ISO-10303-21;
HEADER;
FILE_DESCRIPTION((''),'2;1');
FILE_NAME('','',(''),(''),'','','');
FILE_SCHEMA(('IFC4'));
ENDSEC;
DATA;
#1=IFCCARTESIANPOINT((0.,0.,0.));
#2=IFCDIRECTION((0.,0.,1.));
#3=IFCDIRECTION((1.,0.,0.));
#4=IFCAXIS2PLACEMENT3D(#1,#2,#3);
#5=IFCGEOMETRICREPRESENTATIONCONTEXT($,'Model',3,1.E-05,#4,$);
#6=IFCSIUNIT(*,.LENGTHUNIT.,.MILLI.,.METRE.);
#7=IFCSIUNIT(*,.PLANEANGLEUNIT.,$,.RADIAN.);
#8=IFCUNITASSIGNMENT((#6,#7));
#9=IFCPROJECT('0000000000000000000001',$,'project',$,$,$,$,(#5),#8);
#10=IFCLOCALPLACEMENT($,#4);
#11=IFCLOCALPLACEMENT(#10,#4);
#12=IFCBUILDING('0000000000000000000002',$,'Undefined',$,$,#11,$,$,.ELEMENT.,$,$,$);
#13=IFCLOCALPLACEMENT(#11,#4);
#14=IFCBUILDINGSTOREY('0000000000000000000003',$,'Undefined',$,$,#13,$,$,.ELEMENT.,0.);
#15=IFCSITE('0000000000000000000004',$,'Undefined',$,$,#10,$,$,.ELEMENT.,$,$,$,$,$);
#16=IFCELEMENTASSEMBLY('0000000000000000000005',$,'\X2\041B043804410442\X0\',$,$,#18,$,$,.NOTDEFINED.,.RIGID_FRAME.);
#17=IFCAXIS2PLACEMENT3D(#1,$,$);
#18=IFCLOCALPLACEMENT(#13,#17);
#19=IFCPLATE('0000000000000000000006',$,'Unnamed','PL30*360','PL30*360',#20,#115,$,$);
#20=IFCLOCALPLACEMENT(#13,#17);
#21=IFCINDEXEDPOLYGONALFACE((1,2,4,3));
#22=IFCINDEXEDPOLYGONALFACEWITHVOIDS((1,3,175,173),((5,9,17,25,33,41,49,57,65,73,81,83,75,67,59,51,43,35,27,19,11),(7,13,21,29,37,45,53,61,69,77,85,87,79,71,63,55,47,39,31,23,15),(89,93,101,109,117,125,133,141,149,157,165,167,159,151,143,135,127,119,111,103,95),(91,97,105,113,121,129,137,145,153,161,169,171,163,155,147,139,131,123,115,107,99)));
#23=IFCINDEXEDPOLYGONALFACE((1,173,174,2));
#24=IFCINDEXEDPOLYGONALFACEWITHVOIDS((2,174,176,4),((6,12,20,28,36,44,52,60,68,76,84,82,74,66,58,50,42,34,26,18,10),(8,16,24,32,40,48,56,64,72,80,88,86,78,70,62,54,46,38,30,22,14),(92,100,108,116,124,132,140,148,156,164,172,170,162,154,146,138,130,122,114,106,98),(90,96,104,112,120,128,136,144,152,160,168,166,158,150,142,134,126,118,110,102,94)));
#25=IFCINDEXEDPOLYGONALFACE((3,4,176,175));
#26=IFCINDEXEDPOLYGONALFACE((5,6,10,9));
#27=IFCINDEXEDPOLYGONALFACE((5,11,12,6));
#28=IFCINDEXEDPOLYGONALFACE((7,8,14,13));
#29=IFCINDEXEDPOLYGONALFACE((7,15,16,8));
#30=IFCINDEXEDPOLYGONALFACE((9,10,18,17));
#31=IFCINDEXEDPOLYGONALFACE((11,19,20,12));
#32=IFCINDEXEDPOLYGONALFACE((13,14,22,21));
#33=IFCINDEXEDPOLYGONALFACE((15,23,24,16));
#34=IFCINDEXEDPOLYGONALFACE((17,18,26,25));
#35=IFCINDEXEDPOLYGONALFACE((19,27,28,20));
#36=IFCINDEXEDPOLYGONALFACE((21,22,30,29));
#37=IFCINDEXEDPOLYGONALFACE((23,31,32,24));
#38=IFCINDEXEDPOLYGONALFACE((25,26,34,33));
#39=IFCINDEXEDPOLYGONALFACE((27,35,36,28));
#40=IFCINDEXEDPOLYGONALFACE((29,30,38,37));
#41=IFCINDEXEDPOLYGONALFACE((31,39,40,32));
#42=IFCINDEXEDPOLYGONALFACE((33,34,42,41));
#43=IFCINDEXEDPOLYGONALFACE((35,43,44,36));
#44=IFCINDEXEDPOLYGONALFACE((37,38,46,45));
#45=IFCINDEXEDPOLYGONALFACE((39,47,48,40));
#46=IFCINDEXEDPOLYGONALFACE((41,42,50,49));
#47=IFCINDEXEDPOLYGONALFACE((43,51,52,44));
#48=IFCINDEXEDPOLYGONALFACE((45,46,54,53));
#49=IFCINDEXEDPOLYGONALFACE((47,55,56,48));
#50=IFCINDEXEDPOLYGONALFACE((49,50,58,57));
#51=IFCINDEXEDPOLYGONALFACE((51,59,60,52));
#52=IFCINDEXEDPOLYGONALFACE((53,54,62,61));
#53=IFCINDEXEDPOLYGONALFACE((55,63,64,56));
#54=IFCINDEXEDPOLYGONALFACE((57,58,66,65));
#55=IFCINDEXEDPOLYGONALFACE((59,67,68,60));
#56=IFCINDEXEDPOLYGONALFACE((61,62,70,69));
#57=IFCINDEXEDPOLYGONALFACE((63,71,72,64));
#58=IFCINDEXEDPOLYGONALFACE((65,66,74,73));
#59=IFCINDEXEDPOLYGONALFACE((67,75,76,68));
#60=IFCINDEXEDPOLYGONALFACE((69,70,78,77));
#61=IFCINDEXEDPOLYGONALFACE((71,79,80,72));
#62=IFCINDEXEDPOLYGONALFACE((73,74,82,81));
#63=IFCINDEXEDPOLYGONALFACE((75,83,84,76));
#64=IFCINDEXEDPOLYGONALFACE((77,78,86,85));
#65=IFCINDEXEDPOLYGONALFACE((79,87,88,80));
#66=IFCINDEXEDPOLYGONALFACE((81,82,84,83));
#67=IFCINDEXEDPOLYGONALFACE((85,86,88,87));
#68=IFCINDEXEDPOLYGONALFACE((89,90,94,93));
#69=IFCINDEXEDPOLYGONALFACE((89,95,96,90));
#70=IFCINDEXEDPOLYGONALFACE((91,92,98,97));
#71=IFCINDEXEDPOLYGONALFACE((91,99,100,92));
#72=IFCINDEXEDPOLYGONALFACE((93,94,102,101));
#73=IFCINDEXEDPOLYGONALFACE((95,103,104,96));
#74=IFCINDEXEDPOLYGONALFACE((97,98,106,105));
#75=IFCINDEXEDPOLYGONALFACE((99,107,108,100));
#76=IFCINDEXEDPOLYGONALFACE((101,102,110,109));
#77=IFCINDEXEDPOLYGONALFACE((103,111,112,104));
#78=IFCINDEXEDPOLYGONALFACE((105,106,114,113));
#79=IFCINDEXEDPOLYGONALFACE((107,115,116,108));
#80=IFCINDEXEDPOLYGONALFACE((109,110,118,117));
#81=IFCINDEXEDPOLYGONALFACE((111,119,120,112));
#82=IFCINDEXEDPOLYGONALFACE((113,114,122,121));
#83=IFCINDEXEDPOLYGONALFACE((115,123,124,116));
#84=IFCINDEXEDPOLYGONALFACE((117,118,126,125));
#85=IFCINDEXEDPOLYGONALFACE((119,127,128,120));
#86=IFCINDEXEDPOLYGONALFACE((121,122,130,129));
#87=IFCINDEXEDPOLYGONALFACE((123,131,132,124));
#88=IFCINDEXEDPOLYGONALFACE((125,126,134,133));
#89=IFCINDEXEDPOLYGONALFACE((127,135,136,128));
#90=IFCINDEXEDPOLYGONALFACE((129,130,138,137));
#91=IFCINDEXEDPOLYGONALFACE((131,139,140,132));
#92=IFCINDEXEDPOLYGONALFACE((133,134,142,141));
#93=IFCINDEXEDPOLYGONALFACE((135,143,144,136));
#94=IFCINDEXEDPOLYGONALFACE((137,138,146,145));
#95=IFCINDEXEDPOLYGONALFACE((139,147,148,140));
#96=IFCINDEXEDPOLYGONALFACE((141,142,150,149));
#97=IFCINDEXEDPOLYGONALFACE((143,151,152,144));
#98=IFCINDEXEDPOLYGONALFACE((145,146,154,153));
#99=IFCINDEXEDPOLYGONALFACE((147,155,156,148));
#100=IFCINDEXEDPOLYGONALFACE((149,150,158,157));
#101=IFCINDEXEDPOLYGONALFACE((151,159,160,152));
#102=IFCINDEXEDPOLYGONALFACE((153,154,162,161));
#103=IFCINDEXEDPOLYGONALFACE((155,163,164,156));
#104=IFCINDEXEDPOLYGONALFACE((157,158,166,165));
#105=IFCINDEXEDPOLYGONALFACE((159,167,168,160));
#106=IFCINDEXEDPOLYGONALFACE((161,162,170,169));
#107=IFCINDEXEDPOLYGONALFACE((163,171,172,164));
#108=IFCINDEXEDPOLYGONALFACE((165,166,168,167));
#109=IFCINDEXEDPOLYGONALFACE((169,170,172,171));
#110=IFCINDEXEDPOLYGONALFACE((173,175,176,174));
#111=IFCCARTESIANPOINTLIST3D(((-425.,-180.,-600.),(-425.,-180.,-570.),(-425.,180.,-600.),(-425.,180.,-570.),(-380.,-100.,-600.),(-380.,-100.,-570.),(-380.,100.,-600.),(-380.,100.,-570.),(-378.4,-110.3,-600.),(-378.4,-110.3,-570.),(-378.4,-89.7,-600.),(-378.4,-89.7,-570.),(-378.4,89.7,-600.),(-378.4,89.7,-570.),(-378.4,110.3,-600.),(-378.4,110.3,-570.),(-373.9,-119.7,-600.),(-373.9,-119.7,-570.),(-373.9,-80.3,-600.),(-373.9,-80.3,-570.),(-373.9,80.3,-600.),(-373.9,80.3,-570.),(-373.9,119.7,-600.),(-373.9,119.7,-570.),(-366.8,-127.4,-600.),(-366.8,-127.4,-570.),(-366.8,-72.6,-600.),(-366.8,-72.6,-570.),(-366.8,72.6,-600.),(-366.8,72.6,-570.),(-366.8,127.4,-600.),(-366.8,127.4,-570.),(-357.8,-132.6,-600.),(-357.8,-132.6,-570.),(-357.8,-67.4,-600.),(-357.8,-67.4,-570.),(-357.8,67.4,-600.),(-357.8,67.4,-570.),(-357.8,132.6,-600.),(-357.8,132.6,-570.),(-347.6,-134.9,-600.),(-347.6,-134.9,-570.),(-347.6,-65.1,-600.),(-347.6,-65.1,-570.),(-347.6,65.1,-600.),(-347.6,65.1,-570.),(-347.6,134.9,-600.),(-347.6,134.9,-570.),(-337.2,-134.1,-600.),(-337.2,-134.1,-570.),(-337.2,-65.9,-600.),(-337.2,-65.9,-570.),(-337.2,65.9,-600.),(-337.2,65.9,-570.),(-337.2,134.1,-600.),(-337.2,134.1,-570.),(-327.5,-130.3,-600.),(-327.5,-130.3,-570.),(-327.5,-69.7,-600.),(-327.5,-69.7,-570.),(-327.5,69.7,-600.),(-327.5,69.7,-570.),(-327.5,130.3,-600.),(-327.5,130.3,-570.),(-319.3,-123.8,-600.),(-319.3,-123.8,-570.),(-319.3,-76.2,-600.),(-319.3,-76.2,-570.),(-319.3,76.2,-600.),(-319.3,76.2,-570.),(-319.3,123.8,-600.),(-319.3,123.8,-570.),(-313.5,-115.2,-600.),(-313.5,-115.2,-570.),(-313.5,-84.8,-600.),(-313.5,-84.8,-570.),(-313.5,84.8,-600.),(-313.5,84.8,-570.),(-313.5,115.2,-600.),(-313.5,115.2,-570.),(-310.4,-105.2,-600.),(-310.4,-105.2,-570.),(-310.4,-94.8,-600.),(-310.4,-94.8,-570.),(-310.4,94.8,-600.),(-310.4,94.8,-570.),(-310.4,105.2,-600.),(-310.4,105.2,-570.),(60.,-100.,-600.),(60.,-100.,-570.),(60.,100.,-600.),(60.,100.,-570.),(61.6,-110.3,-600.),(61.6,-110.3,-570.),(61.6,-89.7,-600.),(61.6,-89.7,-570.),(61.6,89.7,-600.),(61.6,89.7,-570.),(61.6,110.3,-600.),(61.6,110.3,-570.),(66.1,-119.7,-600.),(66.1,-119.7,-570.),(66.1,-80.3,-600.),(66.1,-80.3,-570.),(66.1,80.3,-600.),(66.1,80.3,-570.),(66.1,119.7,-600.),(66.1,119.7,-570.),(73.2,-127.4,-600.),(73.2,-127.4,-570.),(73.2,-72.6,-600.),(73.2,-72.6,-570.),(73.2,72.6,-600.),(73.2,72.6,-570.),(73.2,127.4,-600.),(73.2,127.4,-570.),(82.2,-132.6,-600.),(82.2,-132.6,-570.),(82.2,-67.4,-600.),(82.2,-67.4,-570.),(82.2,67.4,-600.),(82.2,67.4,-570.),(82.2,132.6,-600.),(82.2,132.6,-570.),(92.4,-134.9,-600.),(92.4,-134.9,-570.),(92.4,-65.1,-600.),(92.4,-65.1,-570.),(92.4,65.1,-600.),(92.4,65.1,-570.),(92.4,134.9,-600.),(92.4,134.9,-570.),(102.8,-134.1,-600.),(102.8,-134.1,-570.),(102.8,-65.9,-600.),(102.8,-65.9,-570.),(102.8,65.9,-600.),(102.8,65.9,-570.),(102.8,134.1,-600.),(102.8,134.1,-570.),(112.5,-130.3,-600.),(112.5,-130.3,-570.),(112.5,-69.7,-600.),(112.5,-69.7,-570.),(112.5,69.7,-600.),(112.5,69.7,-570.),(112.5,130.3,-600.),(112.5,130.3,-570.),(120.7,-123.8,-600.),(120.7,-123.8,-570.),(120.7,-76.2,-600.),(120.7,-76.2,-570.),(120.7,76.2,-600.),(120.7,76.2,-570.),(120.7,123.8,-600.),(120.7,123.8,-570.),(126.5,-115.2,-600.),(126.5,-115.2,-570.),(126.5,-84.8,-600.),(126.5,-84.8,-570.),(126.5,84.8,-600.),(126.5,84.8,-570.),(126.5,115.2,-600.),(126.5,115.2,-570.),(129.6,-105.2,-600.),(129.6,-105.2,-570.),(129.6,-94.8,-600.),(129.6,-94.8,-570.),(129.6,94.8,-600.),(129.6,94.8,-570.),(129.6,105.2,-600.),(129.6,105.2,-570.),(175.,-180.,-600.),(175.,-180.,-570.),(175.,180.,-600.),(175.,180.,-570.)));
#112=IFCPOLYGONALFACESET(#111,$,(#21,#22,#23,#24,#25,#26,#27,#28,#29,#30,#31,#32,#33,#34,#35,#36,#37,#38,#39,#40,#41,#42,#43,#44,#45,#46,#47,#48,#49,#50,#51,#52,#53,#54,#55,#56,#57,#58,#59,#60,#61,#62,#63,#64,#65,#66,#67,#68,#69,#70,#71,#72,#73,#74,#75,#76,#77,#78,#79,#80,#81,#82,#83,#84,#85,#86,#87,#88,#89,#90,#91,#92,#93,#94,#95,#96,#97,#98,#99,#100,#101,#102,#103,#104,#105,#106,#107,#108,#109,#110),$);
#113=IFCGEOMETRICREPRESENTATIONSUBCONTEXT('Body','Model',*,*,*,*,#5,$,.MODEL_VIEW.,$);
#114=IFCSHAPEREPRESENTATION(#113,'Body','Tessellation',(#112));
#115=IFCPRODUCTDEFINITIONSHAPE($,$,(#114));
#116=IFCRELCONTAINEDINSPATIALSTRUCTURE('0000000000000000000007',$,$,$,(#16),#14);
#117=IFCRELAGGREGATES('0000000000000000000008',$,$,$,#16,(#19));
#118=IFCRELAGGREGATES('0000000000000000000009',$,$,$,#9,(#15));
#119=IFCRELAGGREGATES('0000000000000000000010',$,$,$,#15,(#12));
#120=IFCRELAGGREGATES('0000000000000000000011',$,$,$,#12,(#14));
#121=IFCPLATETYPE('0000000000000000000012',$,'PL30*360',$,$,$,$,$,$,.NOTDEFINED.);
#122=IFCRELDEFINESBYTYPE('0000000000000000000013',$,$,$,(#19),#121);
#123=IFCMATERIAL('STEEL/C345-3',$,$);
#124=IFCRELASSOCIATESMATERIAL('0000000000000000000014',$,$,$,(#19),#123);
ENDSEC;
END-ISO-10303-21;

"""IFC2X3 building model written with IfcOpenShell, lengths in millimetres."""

from ifc_helpers import new_model, si_unit, frame, origin_with_axes, origin_2d_with_axis, place, context, subcontext, project, spatial, polyline, circle, outline, extrude, boolean, material, type_object, element, aggregate, save


model = new_model("IFC2X3")

# Units and contexts
model_context = context("Model", 3, precision=1e-05, world=origin_with_axes())
body_context = subcontext(model_context, "Body", "Model", "MODEL_VIEW")
ifc_project = project(units=[si_unit("LENGTHUNIT", "METRE", prefix="MILLI"), si_unit("PLANEANGLEUNIT", "RADIAN")], contexts=[model_context])

# Site, building, storey
site_placement = place(None, origin_with_axes())
site = spatial("IfcSite", under=ifc_project, at=site_placement, Name="Undefined", CompositionType="ELEMENT")
building_placement = place(site_placement, origin_with_axes())
building = spatial("IfcBuilding", under=site, at=building_placement, Name="Undefined", CompositionType="ELEMENT")
storey_placement = place(building_placement, origin_with_axes())
storey = spatial("IfcBuildingStorey", under=building, at=storey_placement, Name="Undefined", CompositionType="ELEMENT", Elevation=0.0)

# Shared definitions
ifc_material_1 = material(Name="STEEL/C345-3")

# Element assembly, plate
assembly_1_placement = place(storey_placement, origin_with_axes())
assembly_1 = element("IfcElementAssembly", 1, at=assembly_1_placement, inside=storey, Name="Лист", AssemblyPlace="NOTDEFINED", PredefinedType="RIGID_FRAME")
plate_type_1 = type_object("IfcPlateType", Name="PL30*360", PredefinedType="NOTDEFINED")
plate_1_placement = place(assembly_1_placement, frame((-425.0, 180.0, -585.0), z_axis=(0.0, 0.0, 1.0), x_axis=(0.0, -1.0, 0.0)))
plate_1 = element("IfcPlate", 2, at=plate_1_placement, type_object=plate_type_1, material=ifc_material_1, Name="Unnamed", Description="PL30*360", ObjectType="PL30*360", context=body_context, shape_type="CSG", body=[
    boolean("DIFFERENCE", boolean("DIFFERENCE", boolean("DIFFERENCE", boolean("DIFFERENCE", extrude(outline(polyline([(0.0, 0.0), (360.0, 0.0), (360.0, 600.0), (0.0, 600.0), (0.0, 0.0)])), frame((0.0, 0.0, -15.0), z_axis=(0.0, 0.0, 1.0), x_axis=(1.0, 0.0, 0.0)), (0.0, 0.0, 1.0), 30.0), extrude(circle(Radius=35.0, at=origin_2d_with_axis()), frame((80.0, 520.0, 25.0), z_axis=(0.0, 0.0, -1.0), x_axis=(0.0, -1.0, 0.0)), (0.0, 0.0, 1.0), 60.0)), extrude(circle(Radius=35.0, at=origin_2d_with_axis()), frame((280.0, 520.0, 25.0), z_axis=(0.0, 0.0, -1.0), x_axis=(0.0, -1.0, 0.0)), (0.0, 0.0, 1.0), 60.0)), extrude(circle(Radius=35.0, at=origin_2d_with_axis()), frame((80.0, 80.0, 25.0), z_axis=(0.0, 0.0, -1.0), x_axis=(0.0, -1.0, 0.0)), (0.0, 0.0, 1.0), 60.0)), extrude(circle(Radius=35.0, at=origin_2d_with_axis()), frame((280.0, 80.0, 25.0), z_axis=(0.0, 0.0, -1.0), x_axis=(0.0, -1.0, 0.0)), (0.0, 0.0, 1.0), 60.0)),
])
aggregate(assembly_1, [plate_1])

save(model, "model.ifc")
